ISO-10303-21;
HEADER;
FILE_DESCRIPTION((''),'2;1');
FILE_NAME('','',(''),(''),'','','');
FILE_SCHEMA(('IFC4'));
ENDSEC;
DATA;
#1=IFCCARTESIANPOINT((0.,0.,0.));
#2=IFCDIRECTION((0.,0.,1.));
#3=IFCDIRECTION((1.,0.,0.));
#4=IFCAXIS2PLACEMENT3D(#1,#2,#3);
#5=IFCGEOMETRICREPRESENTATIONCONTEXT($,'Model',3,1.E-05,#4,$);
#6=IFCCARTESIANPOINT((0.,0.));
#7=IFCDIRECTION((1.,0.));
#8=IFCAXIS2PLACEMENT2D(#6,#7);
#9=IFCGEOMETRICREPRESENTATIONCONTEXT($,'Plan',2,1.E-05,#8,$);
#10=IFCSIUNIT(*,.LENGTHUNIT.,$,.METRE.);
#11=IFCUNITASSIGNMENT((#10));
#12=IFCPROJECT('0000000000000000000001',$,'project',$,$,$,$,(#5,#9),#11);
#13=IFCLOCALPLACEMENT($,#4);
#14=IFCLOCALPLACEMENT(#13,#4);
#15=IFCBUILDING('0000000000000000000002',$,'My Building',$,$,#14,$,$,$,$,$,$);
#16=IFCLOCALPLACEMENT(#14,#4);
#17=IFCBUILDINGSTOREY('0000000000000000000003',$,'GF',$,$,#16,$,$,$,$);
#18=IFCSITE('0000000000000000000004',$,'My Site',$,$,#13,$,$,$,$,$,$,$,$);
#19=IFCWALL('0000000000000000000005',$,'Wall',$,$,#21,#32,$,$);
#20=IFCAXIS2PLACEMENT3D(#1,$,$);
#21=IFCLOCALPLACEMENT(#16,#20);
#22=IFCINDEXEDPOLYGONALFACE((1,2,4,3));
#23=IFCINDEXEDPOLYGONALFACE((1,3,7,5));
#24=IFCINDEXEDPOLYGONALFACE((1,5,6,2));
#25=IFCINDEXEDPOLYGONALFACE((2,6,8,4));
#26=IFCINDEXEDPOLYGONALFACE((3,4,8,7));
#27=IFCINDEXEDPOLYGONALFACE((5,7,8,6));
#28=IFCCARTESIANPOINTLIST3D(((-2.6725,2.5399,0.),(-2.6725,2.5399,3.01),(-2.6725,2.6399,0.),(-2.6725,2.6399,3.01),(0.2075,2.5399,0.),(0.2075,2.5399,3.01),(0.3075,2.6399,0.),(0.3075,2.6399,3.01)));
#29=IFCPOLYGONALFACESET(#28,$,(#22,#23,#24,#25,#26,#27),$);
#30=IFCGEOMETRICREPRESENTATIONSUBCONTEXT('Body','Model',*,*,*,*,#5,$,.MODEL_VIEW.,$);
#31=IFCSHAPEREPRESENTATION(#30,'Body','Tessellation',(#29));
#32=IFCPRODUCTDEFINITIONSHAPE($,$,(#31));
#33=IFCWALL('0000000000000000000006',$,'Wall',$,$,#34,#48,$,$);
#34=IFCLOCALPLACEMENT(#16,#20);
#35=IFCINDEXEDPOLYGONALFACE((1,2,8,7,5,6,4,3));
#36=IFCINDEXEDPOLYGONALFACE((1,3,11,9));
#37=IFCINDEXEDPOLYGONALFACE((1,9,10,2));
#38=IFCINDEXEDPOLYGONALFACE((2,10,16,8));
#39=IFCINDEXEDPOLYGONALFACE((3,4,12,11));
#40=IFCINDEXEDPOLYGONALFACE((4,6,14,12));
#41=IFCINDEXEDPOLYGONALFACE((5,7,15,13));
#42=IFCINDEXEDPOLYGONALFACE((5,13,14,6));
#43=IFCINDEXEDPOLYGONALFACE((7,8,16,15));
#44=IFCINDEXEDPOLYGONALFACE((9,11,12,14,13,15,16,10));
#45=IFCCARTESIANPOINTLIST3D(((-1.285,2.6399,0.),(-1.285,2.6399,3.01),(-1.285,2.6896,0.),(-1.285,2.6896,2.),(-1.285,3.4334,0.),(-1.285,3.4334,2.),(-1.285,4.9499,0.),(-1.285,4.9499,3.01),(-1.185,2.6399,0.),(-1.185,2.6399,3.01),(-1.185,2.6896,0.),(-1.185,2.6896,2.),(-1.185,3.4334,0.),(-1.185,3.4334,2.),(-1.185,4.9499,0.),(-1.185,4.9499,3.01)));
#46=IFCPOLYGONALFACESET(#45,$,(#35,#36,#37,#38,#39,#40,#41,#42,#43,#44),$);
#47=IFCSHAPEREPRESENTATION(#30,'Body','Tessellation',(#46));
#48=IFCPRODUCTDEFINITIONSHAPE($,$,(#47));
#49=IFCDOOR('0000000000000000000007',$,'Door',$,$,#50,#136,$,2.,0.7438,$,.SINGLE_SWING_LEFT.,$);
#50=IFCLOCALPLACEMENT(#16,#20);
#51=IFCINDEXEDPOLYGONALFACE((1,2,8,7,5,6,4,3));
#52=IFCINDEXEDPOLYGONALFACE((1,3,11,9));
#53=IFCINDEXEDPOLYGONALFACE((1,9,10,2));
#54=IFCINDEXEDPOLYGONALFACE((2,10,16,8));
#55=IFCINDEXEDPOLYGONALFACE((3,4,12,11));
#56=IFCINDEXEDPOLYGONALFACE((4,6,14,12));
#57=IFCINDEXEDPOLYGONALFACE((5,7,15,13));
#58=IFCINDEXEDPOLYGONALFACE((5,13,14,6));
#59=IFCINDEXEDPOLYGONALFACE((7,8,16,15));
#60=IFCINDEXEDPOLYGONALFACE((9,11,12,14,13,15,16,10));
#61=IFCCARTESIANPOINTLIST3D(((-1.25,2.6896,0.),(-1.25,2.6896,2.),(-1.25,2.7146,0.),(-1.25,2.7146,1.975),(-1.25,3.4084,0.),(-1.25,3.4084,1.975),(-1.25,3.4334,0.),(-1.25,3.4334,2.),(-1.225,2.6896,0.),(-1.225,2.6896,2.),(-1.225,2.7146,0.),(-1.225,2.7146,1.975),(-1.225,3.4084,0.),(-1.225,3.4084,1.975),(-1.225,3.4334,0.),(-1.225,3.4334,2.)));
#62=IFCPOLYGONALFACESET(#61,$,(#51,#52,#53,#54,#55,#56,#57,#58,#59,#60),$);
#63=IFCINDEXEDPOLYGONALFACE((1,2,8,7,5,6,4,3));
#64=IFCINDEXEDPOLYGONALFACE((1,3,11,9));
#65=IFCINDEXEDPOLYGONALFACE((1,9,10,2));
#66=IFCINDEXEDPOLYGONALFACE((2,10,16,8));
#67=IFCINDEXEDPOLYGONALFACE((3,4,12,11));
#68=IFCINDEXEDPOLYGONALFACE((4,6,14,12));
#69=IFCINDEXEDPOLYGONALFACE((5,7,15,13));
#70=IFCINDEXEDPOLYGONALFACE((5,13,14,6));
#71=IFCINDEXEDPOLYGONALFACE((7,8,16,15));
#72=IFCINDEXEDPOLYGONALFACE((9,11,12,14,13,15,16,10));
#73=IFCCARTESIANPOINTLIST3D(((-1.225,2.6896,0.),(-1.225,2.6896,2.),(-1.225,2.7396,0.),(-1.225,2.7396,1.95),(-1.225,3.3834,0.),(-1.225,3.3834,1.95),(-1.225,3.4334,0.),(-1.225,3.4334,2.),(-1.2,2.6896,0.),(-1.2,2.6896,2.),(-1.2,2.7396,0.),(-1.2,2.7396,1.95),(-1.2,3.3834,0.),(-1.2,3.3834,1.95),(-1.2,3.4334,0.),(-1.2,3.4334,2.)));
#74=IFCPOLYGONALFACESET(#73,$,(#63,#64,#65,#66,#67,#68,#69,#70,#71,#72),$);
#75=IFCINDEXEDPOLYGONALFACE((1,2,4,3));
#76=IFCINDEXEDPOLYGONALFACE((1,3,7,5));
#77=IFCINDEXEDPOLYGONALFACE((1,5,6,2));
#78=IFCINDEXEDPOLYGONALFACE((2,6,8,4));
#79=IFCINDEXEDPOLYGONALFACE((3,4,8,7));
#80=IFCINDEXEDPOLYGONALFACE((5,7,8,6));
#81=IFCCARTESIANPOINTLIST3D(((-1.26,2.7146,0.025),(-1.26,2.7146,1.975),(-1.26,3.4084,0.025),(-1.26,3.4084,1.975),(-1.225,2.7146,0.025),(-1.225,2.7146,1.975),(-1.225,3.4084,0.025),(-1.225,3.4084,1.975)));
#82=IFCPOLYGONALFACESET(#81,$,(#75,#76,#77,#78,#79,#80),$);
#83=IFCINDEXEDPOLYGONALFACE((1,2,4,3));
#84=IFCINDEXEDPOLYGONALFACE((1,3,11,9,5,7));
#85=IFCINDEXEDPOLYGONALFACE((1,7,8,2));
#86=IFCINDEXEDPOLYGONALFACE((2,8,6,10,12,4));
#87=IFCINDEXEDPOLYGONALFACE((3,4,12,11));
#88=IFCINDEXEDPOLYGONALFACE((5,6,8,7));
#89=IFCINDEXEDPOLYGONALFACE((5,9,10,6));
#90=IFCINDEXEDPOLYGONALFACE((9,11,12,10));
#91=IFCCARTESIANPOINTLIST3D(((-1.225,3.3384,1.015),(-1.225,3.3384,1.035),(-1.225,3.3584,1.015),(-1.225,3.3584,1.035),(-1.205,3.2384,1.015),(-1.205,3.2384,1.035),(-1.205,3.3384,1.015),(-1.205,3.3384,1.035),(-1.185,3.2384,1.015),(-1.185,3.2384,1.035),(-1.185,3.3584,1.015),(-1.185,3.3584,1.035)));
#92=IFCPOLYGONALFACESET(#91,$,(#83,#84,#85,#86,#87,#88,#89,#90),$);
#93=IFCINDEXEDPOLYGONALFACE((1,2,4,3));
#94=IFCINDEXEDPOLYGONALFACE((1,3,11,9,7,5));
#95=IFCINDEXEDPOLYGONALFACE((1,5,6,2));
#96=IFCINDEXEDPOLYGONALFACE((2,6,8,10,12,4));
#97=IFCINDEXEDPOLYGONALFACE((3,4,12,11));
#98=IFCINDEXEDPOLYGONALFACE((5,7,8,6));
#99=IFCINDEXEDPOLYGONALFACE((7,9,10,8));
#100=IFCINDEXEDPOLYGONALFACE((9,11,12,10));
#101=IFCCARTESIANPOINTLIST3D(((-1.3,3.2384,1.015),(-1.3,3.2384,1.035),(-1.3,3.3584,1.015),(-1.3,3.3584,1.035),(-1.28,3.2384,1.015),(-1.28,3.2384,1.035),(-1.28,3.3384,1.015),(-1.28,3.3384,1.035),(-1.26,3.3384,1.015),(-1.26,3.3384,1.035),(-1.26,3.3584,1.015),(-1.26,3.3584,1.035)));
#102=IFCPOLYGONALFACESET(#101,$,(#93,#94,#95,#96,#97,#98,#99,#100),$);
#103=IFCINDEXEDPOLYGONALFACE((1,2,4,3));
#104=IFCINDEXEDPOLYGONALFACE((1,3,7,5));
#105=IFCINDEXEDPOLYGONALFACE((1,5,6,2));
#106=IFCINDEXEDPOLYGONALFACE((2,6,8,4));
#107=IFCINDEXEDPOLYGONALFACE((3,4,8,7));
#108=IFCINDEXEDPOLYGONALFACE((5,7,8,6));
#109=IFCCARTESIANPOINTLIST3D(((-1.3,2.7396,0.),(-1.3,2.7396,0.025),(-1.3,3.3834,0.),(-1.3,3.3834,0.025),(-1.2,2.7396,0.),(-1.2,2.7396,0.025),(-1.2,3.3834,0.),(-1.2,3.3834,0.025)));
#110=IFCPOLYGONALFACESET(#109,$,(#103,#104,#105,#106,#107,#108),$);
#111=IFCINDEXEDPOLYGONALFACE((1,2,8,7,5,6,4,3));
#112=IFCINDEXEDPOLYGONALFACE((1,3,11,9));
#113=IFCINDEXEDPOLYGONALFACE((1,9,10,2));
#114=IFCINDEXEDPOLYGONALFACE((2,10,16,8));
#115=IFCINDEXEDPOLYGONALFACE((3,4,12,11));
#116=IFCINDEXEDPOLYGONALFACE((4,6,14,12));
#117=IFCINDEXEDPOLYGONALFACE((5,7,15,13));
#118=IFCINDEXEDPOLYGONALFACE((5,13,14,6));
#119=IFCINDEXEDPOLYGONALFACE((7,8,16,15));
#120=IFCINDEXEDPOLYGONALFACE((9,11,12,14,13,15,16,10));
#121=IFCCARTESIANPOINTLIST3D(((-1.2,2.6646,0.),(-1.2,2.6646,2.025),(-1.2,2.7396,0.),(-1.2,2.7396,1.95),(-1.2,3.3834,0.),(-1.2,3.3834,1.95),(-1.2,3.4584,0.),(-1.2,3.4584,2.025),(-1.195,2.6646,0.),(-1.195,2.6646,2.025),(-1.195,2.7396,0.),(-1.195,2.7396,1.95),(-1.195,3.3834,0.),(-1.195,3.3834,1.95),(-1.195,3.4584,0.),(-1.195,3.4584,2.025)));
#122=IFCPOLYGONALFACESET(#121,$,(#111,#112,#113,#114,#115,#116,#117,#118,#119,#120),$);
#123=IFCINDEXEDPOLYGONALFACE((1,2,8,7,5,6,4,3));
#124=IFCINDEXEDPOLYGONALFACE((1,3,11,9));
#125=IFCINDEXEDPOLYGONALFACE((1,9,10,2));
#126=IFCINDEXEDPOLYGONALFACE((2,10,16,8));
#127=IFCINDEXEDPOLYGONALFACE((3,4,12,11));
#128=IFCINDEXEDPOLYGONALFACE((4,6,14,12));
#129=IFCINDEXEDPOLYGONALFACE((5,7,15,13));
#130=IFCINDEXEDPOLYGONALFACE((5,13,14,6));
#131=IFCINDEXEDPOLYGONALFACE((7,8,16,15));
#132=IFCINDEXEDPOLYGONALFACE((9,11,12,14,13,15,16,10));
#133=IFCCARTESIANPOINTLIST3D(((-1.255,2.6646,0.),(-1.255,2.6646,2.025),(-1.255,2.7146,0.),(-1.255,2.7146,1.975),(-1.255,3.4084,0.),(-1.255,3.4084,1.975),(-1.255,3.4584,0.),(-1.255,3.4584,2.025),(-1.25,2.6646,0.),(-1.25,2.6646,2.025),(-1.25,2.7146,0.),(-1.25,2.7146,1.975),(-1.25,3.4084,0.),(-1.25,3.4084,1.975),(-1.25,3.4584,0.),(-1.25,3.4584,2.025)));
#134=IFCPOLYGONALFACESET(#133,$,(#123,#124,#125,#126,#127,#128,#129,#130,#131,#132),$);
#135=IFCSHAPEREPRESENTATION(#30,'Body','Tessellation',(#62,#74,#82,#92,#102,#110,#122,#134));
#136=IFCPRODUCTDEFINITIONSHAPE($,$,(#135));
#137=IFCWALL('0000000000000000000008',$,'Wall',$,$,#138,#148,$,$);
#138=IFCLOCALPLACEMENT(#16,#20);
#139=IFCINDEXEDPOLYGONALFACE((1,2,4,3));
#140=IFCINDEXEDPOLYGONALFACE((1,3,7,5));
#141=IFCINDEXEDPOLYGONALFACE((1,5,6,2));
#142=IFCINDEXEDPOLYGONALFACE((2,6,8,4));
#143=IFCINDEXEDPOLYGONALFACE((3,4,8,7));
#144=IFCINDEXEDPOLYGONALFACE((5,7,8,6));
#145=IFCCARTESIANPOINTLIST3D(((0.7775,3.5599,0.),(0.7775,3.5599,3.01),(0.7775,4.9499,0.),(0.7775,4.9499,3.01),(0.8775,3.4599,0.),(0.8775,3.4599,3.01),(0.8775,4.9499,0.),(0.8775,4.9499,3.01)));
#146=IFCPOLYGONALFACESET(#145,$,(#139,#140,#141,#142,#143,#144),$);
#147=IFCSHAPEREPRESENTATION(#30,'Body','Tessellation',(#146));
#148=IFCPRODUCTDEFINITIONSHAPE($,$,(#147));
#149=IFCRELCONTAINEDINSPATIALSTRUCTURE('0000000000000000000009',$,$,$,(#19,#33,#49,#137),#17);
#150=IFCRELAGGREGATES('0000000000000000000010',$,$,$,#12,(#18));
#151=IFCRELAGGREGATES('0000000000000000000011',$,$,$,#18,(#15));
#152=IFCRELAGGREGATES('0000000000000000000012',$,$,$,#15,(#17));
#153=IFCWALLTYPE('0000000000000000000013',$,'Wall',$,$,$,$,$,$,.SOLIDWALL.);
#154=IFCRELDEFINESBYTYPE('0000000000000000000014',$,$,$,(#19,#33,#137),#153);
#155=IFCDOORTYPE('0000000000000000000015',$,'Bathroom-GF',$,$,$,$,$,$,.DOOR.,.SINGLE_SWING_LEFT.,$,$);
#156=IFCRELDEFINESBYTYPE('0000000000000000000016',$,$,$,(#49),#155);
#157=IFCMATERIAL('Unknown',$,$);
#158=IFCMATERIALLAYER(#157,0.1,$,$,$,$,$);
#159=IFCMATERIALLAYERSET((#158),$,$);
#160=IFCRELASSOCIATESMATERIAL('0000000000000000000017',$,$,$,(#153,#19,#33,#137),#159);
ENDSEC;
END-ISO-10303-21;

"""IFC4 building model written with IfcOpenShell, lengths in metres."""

from ifc_helpers import new_model, entity, si_unit, frame, origin_with_axes, origin_2d_with_axis, place, context, subcontext, project, spatial, line, indexed_curve, outline, extrude, shape, source, transform, mapped, material, layer, layer_set, layer_usage, type_object, type_shapes, element, fill, save


model = new_model("IFC4")

# Units and contexts
model_context = context("Model", 3, precision=1e-05, world=origin_with_axes())
plan_context = context("Plan", 2, precision=1e-05, world=origin_2d_with_axis())
body_context_1 = subcontext(model_context, "Body", "Model", "MODEL_VIEW")
body_context_2 = subcontext(plan_context, "Body", "Plan", "PLAN_VIEW")
ifc_project = project(units=[si_unit("LENGTHUNIT", "METRE")], contexts=[model_context, plan_context])

# Site, building, storey
site_placement = place(None, origin_with_axes())
site = spatial("IfcSite", under=ifc_project, at=site_placement, Name="My Site")
building_placement = place(site_placement, origin_with_axes())
building = spatial("IfcBuilding", under=site, at=building_placement, Name="My Building")
storey_placement = place(building_placement, origin_with_axes())
storey = spatial("IfcBuildingStorey", under=building, at=storey_placement, Name="GF")

# Shared definitions
ifc_material_1 = material(Name="Unknown")

# Shared definitions
ifc_layer_1 = layer(ifc_material_1, 0.1)
ifc_layer_set_1 = layer_set([ifc_layer_1])
wall_type = type_object("IfcWallType", Name="Wall", PredefinedType="SOLIDWALL", material=ifc_layer_set_1)

# Wall
ifc_layer_usage_1 = layer_usage(ifc_layer_set_1, "AXIS2", "POSITIVE", 0.0)
wall_1_placement = place(storey_placement, frame((0.3075, 2.6399, 0.0), z_axis=(0.0, 0.0, 1.0), x_axis=(-1.0, 0.0, 0.0)))
element("IfcWall", 1, at=wall_1_placement, inside=storey, type_object=wall_type, material=ifc_layer_usage_1, Name="Wall", context=body_context_1, shape_type="SweptSolid", body=[
    extrude(outline(indexed_curve([(0.0, 0.0), (0.1, 0.1), (2.98, 0.1), (2.98, 0.0)], segments=[line(1, 2, 3, 4, 1)])), origin_with_axes(), (0.0, 0.0, 1.0), 3.01),
])

# Wall, opening, door
ifc_layer_usage_2 = layer_usage(ifc_layer_set_1, "AXIS2", "POSITIVE", 0.0)
wall_2_placement = place(storey_placement, frame((-1.185, 2.6399, 0.0), z_axis=(0.0, 0.0, 1.0), x_axis=(0.0, 1.0, 0.0)))
wall_2 = element("IfcWall", 2, at=wall_2_placement, inside=storey, type_object=wall_type, material=ifc_layer_usage_2, Name="Wall", context=body_context_1, shape_type="SweptSolid", body=[
    extrude(outline(indexed_curve([(0.0, 0.0), (0.0, 0.1), (2.31, 0.1), (2.31, 0.0)], segments=[line(1, 2, 3, 4, 1)])), origin_with_axes(), (0.0, 0.0, 1.0), 3.01),
])
shared_shape_1 = source(origin_with_axes(), body_context_1, "Body", "SweptSolid", [
    extrude(outline(indexed_curve([(0.0, 0.0), (0.7438, 0.0), (0.7438, 2.0), (0.0, 2.0)], segments=[line(1, 2, 3, 4, 1)])), frame((0.0, -0.6, 0.0), z_axis=(0.0, -1.0, 0.0), x_axis=(1.0, 0.0, 0.0)), (0.0, 0.0, -1.0), 1.2),
])
opening_1_placement = place(wall_2_placement, frame((0.0497, 0.015, 0.0), z_axis=(0.0, 0.0, 1.0), x_axis=(1.0, 0.0, 0.0)))
opening_1 = element("IfcOpeningElement", 3, at=opening_1_placement, cuts=wall_2, PredefinedType="OPENING", context=body_context_1, shape_type="MappedRepresentation", body=[
    mapped(shared_shape_1, transform((0.0, 0.0, 0.0), x_axis=(1.0, 0.0, 0.0), y_axis=(0.0, 1.0, 0.0), z_axis=(0.0, 0.0, 1.0), scale=1.0)),
])
door_type_1 = type_object("IfcDoorType", Name="Bathroom-GF", OperationType="SINGLE_SWING_LEFT", PredefinedType="DOOR")
shared_shape_2 = source(origin_with_axes(), body_context_1, "Body", "SweptSolid", [
    extrude(outline(indexed_curve([(0.0, 0.0), (0.0, 2.0), (0.7438, 2.0), (0.7438, 0.0), (0.7188, 0.0), (0.7188, 1.975), (0.025, 1.975), (0.025, 0.0)], segments=[line(1, 2, 3, 4, 5, 6, 7, 8, 1)])), frame((0.0, 0.025, 0.0), z_axis=(0.0, -1.0, 0.0), x_axis=(1.0, 0.0, 0.0)), (0.0, 0.0, -1.0), 0.025),
    extrude(outline(indexed_curve([(0.0, 0.0), (0.0, 2.0), (0.7438, 2.0), (0.7438, 0.0), (0.6938, 0.0), (0.6938, 1.95), (0.05, 1.95), (0.05, 0.0)], segments=[line(1, 2, 3, 4, 5, 6, 7, 8, 1)])), frame((0.0, 0.0, 0.0), z_axis=(0.0, -1.0, 0.0), x_axis=(1.0, 0.0, 0.0)), (0.0, 0.0, -1.0), 0.025),
    extrude(outline(indexed_curve([(0.0, 0.0), (0.6938, 0.0), (0.6938, 0.035), (0.0, 0.035)], segments=[line(1, 2, 3, 4, 1)])), frame((0.025, 0.025, 0.025), z_axis=(0.0, 0.0, 1.0), x_axis=(1.0, 0.0, 0.0)), (0.0, 0.0, 1.0), 1.95),
    extrude(outline(indexed_curve([(0.0, 0.0), (0.0, -0.04), (-0.12, -0.04), (-0.12, -0.02), (-0.02, -0.02), (-0.02, 0.0)], segments=[line(1, 2, 3, 4, 5, 6, 1)])), frame((0.6688, 0.025, 1.015), z_axis=(0.0, 0.0, 1.0), x_axis=(1.0, 0.0, 0.0)), (0.0, 0.0, 1.0), 0.02),
    extrude(outline(indexed_curve([(0.0, 0.0), (0.0, 0.04), (-0.12, 0.04), (-0.12, 0.02), (-0.02, 0.02), (-0.02, 0.0)], segments=[line(1, 2, 3, 4, 5, 6, 1)])), frame((0.6688, 0.06, 1.015), z_axis=(0.0, 0.0, 1.0), x_axis=(1.0, 0.0, 0.0)), (0.0, 0.0, 1.0), 0.02),
    extrude(outline(indexed_curve([(0.0, 0.0), (0.6438, 0.0), (0.6438, 0.1), (0.0, 0.1)], segments=[line(1, 2, 3, 4, 1)])), frame((0.05, 0.0, 0.0), z_axis=(0.0, 0.0, 1.0), x_axis=(1.0, 0.0, 0.0)), (0.0, 0.0, 1.0), 0.025),
    extrude(outline(indexed_curve([(0.0, 0.0), (0.0, 2.025), (0.7938, 2.025), (0.7938, 0.0), (0.7188, 0.0), (0.7188, 1.95), (0.075, 1.95), (0.075, 0.0)], segments=[line(1, 2, 3, 4, 5, 6, 7, 8, 1)])), frame((-0.025, -0.005, 0.0), z_axis=(0.0, -1.0, 0.0), x_axis=(1.0, 0.0, 0.0)), (0.0, 0.0, -1.0), 0.005),
    extrude(outline(indexed_curve([(0.0, 0.0), (0.0, 2.025), (0.7938, 2.025), (0.7938, 0.0), (0.7438, 0.0), (0.7438, 1.975), (0.05, 1.975), (0.05, 0.0)], segments=[line(1, 2, 3, 4, 5, 6, 7, 8, 1)])), frame((-0.025, 0.05, 0.0), z_axis=(0.0, -1.0, 0.0), x_axis=(1.0, 0.0, 0.0)), (0.0, 0.0, -1.0), 0.005),
])
shared_shape_3 = source(origin_with_axes(), body_context_2, "Body", "Curve2D", [
    entity("IfcIndexedPolyCurve", entity("IfcCartesianPointList2D", [[0.0, 0.0], [0.0, 0.05], [0.025, 0.05], [0.025, 0.025], [0.05, 0.025], [0.05, 0.0]]), [entity("IfcLineIndex", [1, 2, 3, 4, 5, 6, 1])]),
    entity("IfcIndexedPolyCurve", entity("IfcCartesianPointList2D", [[0.7438, 0.0], [0.7438, 0.05], [0.7188, 0.05], [0.7188, 0.025], [0.6938, 0.025], [0.6938, 0.0]]), [entity("IfcLineIndex", [1, 2, 3, 4, 5, 6, 1])]),
    entity("IfcTrimmedCurve", entity("IfcEllipse", entity("IfcAxis2Placement2D", entity("IfcCartesianPoint", [0.06, 0.05]), entity("IfcDirection", [1.0, 0.0])), 0.6588, 0.6938), [entity("IfcCartesianPoint", [0.7188, 0.05])], [entity("IfcCartesianPoint", [0.06, 0.7438])], True, "CARTESIAN"),
    entity("IfcIndexedPolyCurve", entity("IfcCartesianPointList2D", [[0.025, 0.05], [0.06, 0.05], [0.06, 0.7438], [0.025, 0.7438]]), [entity("IfcLineIndex", [1, 2, 3, 4, 1])]),
])
type_shapes(door_type_1, [shared_shape_2, shared_shape_3])
door_1_placement = place(opening_1_placement, frame((0.0, 0.0, 0.0), z_axis=(0.0, 0.0, 1.0), x_axis=(1.0, 0.0, 0.0)))
door_1 = element("IfcDoor", 4, at=door_1_placement, inside=storey, type_object=door_type_1, Name="Door", OperationType="SINGLE_SWING_LEFT", OverallHeight=2.0, OverallWidth=0.7438, shapes=[
    shape(body_context_1, "Body", "MappedRepresentation", [mapped(shared_shape_2, transform((0.0, 0.0, 0.0), x_axis=(1.0, 0.0, 0.0), y_axis=(0.0, 1.0, 0.0), z_axis=(0.0, 0.0, 1.0), scale=1.0))]),
    shape(body_context_2, "Body", "MappedRepresentation", [mapped(shared_shape_3, transform((0.0, 0.0, 0.0), x_axis=(1.0, 0.0, 0.0), y_axis=(0.0, 1.0, 0.0), z_axis=(0.0, 0.0, 1.0), scale=1.0))]),
])
fill(opening_1, door_1)

# Wall
ifc_layer_usage_3 = layer_usage(ifc_layer_set_1, "AXIS2", "POSITIVE", 0.0)
wall_3_placement = place(storey_placement, frame((0.7775, 4.9499, 0.0), z_axis=(0.0, 0.0, 1.0), x_axis=(0.0, -1.0, 0.0)))
element("IfcWall", 5, at=wall_3_placement, inside=storey, type_object=wall_type, material=ifc_layer_usage_3, Name="Wall", context=body_context_1, shape_type="SweptSolid", body=[
    extrude(outline(indexed_curve([(0.0, 0.0), (0.0, 0.1), (1.49, 0.1), (1.39, 0.0)], segments=[line(1, 2, 3, 4, 1)])), origin_with_axes(), (0.0, 0.0, 1.0), 3.01),
])

save(model, "model.ifc")
